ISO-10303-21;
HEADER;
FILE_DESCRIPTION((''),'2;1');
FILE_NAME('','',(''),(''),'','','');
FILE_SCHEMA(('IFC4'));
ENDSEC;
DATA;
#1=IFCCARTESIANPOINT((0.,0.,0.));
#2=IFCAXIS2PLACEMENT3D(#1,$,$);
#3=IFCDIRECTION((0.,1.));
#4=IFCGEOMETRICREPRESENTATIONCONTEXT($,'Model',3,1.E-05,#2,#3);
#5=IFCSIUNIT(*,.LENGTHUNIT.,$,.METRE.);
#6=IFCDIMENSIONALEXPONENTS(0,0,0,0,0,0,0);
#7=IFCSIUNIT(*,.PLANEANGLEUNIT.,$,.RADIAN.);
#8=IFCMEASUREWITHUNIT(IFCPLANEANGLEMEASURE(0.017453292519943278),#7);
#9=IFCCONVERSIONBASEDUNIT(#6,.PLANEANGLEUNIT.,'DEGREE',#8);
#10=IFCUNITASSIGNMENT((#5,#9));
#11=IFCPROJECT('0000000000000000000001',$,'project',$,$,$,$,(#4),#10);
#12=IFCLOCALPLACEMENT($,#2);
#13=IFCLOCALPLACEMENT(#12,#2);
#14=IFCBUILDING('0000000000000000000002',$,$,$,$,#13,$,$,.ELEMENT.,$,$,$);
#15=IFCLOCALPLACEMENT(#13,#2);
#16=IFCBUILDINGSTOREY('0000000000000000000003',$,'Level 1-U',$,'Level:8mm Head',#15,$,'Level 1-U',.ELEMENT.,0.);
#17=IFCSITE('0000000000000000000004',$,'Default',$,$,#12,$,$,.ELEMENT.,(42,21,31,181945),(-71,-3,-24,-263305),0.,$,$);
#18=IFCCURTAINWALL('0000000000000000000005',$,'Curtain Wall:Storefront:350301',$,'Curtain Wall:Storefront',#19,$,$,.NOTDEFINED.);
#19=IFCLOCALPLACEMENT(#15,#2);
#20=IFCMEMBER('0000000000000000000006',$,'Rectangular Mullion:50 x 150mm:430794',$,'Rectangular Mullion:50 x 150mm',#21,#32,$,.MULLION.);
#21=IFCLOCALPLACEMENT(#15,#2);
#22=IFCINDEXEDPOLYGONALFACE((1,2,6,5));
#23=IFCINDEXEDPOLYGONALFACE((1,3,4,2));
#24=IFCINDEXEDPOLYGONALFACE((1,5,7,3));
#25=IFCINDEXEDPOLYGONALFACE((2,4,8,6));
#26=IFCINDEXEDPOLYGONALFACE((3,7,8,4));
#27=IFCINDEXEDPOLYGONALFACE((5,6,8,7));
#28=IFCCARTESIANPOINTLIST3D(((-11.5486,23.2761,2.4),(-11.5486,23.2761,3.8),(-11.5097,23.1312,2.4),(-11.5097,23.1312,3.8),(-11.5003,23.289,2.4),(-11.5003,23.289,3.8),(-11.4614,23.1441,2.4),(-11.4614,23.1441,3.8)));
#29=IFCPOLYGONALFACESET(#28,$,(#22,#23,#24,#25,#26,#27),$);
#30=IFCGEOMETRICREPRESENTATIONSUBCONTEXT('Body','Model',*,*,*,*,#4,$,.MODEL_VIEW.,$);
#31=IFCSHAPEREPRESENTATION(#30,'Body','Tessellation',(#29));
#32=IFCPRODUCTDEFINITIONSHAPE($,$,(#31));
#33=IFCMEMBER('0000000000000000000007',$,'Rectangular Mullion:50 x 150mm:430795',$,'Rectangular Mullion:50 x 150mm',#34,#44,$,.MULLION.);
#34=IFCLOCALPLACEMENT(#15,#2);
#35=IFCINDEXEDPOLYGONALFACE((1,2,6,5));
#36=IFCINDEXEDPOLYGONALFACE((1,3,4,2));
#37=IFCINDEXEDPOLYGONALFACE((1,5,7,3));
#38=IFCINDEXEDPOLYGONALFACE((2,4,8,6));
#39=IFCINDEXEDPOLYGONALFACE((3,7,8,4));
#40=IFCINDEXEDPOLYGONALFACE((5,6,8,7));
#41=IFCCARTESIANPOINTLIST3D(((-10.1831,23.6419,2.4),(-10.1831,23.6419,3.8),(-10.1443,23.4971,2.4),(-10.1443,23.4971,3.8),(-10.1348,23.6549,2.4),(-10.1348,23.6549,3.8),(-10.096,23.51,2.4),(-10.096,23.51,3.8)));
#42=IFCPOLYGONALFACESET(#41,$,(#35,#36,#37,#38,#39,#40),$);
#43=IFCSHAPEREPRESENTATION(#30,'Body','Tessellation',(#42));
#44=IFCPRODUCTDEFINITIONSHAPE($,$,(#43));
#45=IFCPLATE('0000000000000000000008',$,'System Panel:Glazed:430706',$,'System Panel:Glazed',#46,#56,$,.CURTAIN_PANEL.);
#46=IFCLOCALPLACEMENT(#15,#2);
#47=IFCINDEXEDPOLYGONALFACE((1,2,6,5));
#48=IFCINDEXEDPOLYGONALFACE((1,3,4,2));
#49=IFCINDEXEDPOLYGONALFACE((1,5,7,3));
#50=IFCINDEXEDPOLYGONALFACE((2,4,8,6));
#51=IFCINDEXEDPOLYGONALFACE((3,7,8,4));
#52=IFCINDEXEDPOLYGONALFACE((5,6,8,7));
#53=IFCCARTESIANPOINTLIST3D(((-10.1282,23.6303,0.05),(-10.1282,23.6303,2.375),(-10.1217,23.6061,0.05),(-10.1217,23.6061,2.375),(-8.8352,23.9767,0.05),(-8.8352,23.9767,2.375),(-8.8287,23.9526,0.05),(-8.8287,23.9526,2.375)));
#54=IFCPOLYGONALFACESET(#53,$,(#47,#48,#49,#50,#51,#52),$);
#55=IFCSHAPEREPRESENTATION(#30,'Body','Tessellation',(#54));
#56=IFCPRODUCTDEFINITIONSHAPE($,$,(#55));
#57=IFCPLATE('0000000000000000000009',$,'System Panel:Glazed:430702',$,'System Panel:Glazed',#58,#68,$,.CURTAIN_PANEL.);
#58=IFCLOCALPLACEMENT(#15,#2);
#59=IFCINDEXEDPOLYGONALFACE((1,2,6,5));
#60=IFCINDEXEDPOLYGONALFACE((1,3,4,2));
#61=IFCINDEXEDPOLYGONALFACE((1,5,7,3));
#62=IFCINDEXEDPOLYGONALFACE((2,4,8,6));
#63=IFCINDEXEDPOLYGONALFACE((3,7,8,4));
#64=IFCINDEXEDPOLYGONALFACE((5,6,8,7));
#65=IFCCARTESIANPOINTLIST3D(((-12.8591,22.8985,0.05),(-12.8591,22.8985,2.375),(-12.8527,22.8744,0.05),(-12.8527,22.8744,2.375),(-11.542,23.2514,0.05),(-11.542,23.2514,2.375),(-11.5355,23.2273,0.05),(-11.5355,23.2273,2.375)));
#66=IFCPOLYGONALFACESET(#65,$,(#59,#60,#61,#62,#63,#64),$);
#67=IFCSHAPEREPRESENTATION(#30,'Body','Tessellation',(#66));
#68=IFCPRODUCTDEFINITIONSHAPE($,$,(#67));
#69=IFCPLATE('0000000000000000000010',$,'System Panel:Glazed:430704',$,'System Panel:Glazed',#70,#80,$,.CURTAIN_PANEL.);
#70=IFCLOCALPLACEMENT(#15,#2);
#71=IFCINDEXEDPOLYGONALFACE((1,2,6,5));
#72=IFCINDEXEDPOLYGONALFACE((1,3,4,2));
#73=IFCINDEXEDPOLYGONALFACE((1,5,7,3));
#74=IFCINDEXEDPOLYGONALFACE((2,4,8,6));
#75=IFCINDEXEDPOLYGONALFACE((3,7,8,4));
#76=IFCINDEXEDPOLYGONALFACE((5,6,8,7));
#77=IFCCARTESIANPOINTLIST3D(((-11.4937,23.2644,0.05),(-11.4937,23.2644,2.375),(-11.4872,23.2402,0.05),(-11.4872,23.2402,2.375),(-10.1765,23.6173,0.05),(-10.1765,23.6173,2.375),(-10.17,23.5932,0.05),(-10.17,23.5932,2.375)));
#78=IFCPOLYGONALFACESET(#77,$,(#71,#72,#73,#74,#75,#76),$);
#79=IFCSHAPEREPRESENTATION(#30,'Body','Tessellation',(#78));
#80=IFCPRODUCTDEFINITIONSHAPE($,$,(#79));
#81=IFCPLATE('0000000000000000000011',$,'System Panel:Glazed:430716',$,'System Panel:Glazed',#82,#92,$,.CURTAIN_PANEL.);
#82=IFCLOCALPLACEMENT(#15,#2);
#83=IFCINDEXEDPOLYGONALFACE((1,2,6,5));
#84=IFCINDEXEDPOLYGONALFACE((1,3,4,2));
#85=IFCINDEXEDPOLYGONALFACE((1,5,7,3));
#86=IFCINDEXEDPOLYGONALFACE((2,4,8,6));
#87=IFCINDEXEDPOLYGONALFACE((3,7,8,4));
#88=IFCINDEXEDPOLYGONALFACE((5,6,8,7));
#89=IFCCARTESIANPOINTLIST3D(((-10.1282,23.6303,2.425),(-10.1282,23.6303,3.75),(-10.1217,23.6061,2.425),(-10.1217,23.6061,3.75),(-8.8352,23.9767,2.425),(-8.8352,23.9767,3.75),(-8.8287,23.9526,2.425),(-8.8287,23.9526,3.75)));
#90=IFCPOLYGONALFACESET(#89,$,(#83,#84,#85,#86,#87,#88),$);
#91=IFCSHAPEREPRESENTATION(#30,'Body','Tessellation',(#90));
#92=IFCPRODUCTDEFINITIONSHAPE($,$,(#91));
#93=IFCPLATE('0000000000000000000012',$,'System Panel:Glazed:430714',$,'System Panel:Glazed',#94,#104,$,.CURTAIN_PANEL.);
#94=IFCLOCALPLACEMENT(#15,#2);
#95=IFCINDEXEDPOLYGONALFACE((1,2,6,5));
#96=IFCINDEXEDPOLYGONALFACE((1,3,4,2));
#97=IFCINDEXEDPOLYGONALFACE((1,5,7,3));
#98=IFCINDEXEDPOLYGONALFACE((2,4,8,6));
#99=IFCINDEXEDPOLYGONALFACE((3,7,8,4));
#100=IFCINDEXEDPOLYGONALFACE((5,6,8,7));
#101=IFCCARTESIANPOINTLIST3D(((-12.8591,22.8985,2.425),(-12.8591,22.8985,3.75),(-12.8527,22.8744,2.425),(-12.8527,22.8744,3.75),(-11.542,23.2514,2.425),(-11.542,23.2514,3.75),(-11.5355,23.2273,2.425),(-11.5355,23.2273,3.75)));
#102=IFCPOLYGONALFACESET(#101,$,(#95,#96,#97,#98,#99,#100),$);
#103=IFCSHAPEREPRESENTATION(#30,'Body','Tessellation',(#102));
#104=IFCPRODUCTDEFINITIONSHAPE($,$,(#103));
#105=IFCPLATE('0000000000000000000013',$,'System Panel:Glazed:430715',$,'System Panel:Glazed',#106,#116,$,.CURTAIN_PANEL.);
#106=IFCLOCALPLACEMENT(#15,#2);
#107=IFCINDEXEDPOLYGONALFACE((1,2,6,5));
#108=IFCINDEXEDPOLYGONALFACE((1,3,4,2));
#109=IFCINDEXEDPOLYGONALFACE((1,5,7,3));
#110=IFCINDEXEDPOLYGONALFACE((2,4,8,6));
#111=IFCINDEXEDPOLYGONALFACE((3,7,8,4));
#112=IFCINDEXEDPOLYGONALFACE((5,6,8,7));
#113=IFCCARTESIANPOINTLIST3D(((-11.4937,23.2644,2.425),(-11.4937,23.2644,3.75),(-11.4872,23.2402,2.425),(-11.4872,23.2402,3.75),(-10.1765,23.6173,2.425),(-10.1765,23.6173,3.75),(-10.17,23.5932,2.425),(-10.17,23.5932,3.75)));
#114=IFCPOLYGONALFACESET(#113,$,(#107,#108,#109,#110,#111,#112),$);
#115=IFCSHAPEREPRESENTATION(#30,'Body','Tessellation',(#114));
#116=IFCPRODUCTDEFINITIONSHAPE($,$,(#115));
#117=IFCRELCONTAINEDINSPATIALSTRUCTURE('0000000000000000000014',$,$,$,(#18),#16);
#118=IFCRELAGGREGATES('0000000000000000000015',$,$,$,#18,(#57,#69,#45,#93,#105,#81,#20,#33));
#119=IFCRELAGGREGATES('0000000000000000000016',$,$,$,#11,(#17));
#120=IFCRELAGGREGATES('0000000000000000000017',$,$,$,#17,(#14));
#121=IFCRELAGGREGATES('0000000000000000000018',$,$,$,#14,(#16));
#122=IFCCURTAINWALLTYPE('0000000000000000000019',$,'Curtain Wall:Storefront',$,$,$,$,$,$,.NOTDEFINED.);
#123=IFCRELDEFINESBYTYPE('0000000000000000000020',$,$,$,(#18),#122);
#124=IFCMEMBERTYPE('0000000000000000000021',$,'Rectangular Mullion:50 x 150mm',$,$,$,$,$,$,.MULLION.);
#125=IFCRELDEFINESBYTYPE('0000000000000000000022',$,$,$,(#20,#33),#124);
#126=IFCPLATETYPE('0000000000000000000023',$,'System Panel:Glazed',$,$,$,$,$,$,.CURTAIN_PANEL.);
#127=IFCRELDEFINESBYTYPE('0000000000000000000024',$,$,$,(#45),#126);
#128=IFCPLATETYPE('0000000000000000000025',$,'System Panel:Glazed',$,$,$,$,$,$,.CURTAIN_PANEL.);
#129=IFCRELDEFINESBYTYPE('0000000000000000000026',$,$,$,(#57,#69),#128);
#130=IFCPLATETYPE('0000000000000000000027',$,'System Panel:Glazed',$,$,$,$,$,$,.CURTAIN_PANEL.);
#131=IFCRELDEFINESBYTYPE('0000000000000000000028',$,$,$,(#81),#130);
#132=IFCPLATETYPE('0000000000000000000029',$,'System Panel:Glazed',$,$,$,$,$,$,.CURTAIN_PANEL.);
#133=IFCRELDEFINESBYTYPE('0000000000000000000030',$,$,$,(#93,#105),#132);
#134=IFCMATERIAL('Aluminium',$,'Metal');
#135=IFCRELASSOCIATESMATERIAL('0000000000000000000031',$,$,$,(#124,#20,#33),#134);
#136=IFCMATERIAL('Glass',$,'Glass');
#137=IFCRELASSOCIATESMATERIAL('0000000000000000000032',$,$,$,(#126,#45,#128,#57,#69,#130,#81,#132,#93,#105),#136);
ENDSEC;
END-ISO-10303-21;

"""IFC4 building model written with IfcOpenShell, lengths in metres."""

from ifc_helpers import new_model, entity, si_unit, converted_unit, direction, frame, origin, place, context, subcontext, project, spatial, indexed_curve, outline, extrude, source, transform, mapped, material, type_object, type_shapes, element, aggregate, save


model = new_model("IFC4")

# Units and contexts
model_context = context("Model", 3, precision=1e-05, world=origin(), true_north=direction((0.0, 1.0)))
body_context = subcontext(model_context, "Body", "Model", "MODEL_VIEW")
ifc_project = project(units=[si_unit("LENGTHUNIT", "METRE"), converted_unit("PLANEANGLEUNIT", "DEGREE", entity("IfcPlaneAngleMeasure", 0.017453292519943278), si_unit("PLANEANGLEUNIT", "RADIAN"), dimensions=[0, 0, 0, 0, 0, 0, 0])], contexts=[model_context])

# Site, building, storey
site_placement = place(None, origin())
site = spatial("IfcSite", under=ifc_project, at=site_placement, Name="Default", CompositionType="ELEMENT", RefLatitude=(42, 21, 31, 181945), RefLongitude=(-71, -3, -24, -263305), RefElevation=0.0)
building_placement = place(site_placement, origin())
building = spatial("IfcBuilding", under=site, at=building_placement, CompositionType="ELEMENT")
storey_placement = place(building_placement, origin())
storey = spatial("IfcBuildingStorey", under=building, at=storey_placement, Name="Level 1-U", ObjectType="Level:8mm Head", LongName="Level 1-U", CompositionType="ELEMENT", Elevation=0.0)

# Curtain wall, members, plates
curtain_wall_type = type_object("IfcCurtainWallType", Name="Curtain Wall:Storefront", PredefinedType="NOTDEFINED")
curtain_wall_placement = place(storey_placement, origin())
curtain_wall = element("IfcCurtainWall", 1, at=curtain_wall_placement, inside=storey, type_object=curtain_wall_type, Name="Curtain Wall:Storefront:350301", ObjectType="Curtain Wall:Storefront", PredefinedType="NOTDEFINED")
ifc_material_1 = material(Name="Aluminium", Category="Metal")
member_type_1 = type_object("IfcMemberType", Name="Rectangular Mullion:50 x 150mm", PredefinedType="MULLION", material=ifc_material_1)
shared_shape_1 = source(origin(), body_context, "Body", "SweptSolid", [
    extrude(outline(indexed_curve([(-0.025, -0.075), (0.025, -0.075), (0.025, 0.075), (-0.025, 0.075), (-0.025, -0.075)], self_intersect=False)), frame((0.0, 0.0, -1.4), z_axis=(0.0, 0.0, 1.0), x_axis=(-1.0, 0.0, 0.0)), (0.0, 0.0, 1.0), 1.4),
])
type_shapes(member_type_1, [shared_shape_1])
member_1_placement = place(curtain_wall_placement, frame((-11.505, 23.2101, 2.4), z_axis=(0.0, 0.0, -1.0), x_axis=(0.965926, 0.258819, 0.0)))
member_1 = element("IfcMember", 2, at=member_1_placement, type_object=member_type_1, material=ifc_material_1, Name="Rectangular Mullion:50 x 150mm:430794", ObjectType="Rectangular Mullion:50 x 150mm", PredefinedType="MULLION", context=body_context, shape_type="MappedRepresentation", body=[
    mapped(shared_shape_1, transform((0.0, 0.0, 0.0), scale=1.0)),
])
member_2_placement = place(curtain_wall_placement, frame((-10.1395, 23.576, 2.4), z_axis=(0.0, 0.0, -1.0), x_axis=(0.965926, 0.258819, 0.0)))
member_2 = element("IfcMember", 3, at=member_2_placement, type_object=member_type_1, material=ifc_material_1, Name="Rectangular Mullion:50 x 150mm:430795", ObjectType="Rectangular Mullion:50 x 150mm", PredefinedType="MULLION", context=body_context, shape_type="MappedRepresentation", body=[
    mapped(shared_shape_1, transform((0.0, 0.0, 0.0), scale=1.0)),
])
ifc_material_2 = material(Name="Glass", Category="Glass")
plate_type_1 = type_object("IfcPlateType", Name="System Panel:Glazed", PredefinedType="CURTAIN_PANEL", material=ifc_material_2)
shared_shape_2 = source(origin(), body_context, "Body", "SweptSolid", [
    extrude(outline(indexed_curve([(-0.0125, -0.6693), (0.0125, -0.6693), (0.0125, 0.6693), (-0.0125, 0.6693), (-0.0125, -0.6693)], self_intersect=False)), frame((0.0, 0.037, 0.0), z_axis=(0.0, 0.0, 1.0), x_axis=(0.0, 1.0, 0.0)), (0.0, 0.0, 1.0), 2.325),
])
type_shapes(plate_type_1, [shared_shape_2])
plate_1_placement = place(curtain_wall_placement, frame((-9.4689, 23.7557, 0.05), z_axis=(0.0, 0.0, 1.0), x_axis=(0.965926, 0.258819, 0.0)))
plate_1 = element("IfcPlate", 4, at=plate_1_placement, type_object=plate_type_1, material=ifc_material_2, Name="System Panel:Glazed:430706", ObjectType="System Panel:Glazed", PredefinedType="CURTAIN_PANEL", context=body_context, shape_type="MappedRepresentation", body=[
    mapped(shared_shape_2, transform((0.0, 0.0, 0.0), scale=1.0)),
])
plate_type_2 = type_object("IfcPlateType", Name="System Panel:Glazed", PredefinedType="CURTAIN_PANEL", material=ifc_material_2)
shared_shape_3 = source(origin(), body_context, "Body", "SweptSolid", [
    extrude(outline(indexed_curve([(-0.0125, -0.6818), (0.0125, -0.6818), (0.0125, 0.6818), (-0.0125, 0.6818), (-0.0125, -0.6818)], self_intersect=False)), frame((0.0, 0.037, 0.0), z_axis=(0.0, 0.0, 1.0), x_axis=(0.0, 1.0, 0.0)), (0.0, 0.0, 1.0), 2.325),
])
type_shapes(plate_type_2, [shared_shape_3])
plate_2_placement = place(curtain_wall_placement, frame((-12.1877, 23.0272, 0.05), z_axis=(0.0, 0.0, 1.0), x_axis=(0.965926, 0.258819, 0.0)))
plate_2 = element("IfcPlate", 5, at=plate_2_placement, type_object=plate_type_2, material=ifc_material_2, Name="System Panel:Glazed:430702", ObjectType="System Panel:Glazed", PredefinedType="CURTAIN_PANEL", context=body_context, shape_type="MappedRepresentation", body=[
    mapped(shared_shape_3, transform((0.0, 0.0, 0.0), scale=1.0)),
])
plate_3_placement = place(curtain_wall_placement, frame((-10.8223, 23.393, 0.05), z_axis=(0.0, 0.0, 1.0), x_axis=(0.965926, 0.258819, 0.0)))
plate_3 = element("IfcPlate", 6, at=plate_3_placement, type_object=plate_type_2, material=ifc_material_2, Name="System Panel:Glazed:430704", ObjectType="System Panel:Glazed", PredefinedType="CURTAIN_PANEL", context=body_context, shape_type="MappedRepresentation", body=[
    mapped(shared_shape_3, transform((0.0, 0.0, 0.0), scale=1.0)),
])
plate_type_3 = type_object("IfcPlateType", Name="System Panel:Glazed", PredefinedType="CURTAIN_PANEL", material=ifc_material_2)
shared_shape_4 = source(origin(), body_context, "Body", "SweptSolid", [
    extrude(outline(indexed_curve([(-0.0125, -0.6693), (0.0125, -0.6693), (0.0125, 0.6693), (-0.0125, 0.6693), (-0.0125, -0.6693)], self_intersect=False)), frame((0.0, 0.037, 0.0), z_axis=(0.0, 0.0, 1.0), x_axis=(0.0, 1.0, 0.0)), (0.0, 0.0, 1.0), 1.325),
])
type_shapes(plate_type_3, [shared_shape_4])
plate_4_placement = place(curtain_wall_placement, frame((-9.4689, 23.7557, 2.425), z_axis=(0.0, 0.0, 1.0), x_axis=(0.965926, 0.258819, 0.0)))
plate_4 = element("IfcPlate", 7, at=plate_4_placement, type_object=plate_type_3, material=ifc_material_2, Name="System Panel:Glazed:430716", ObjectType="System Panel:Glazed", PredefinedType="CURTAIN_PANEL", context=body_context, shape_type="MappedRepresentation", body=[
    mapped(shared_shape_4, transform((0.0, 0.0, 0.0), scale=1.0)),
])
plate_type_4 = type_object("IfcPlateType", Name="System Panel:Glazed", PredefinedType="CURTAIN_PANEL", material=ifc_material_2)
shared_shape_5 = source(origin(), body_context, "Body", "SweptSolid", [
    extrude(outline(indexed_curve([(-0.0125, -0.6818), (0.0125, -0.6818), (0.0125, 0.6818), (-0.0125, 0.6818), (-0.0125, -0.6818)], self_intersect=False)), frame((0.0, 0.037, 0.0), z_axis=(0.0, 0.0, 1.0), x_axis=(0.0, 1.0, 0.0)), (0.0, 0.0, 1.0), 1.325),
])
type_shapes(plate_type_4, [shared_shape_5])
plate_5_placement = place(curtain_wall_placement, frame((-12.1877, 23.0272, 2.425), z_axis=(0.0, 0.0, 1.0), x_axis=(0.965926, 0.258819, 0.0)))
plate_5 = element("IfcPlate", 8, at=plate_5_placement, type_object=plate_type_4, material=ifc_material_2, Name="System Panel:Glazed:430714", ObjectType="System Panel:Glazed", PredefinedType="CURTAIN_PANEL", context=body_context, shape_type="MappedRepresentation", body=[
    mapped(shared_shape_5, transform((0.0, 0.0, 0.0), scale=1.0)),
])
plate_6_placement = place(curtain_wall_placement, frame((-10.8223, 23.393, 2.425), z_axis=(0.0, 0.0, 1.0), x_axis=(0.965926, 0.258819, 0.0)))
plate_6 = element("IfcPlate", 9, at=plate_6_placement, type_object=plate_type_4, material=ifc_material_2, Name="System Panel:Glazed:430715", ObjectType="System Panel:Glazed", PredefinedType="CURTAIN_PANEL", context=body_context, shape_type="MappedRepresentation", body=[
    mapped(shared_shape_5, transform((0.0, 0.0, 0.0), scale=1.0)),
])
aggregate(curtain_wall, [plate_2, plate_3, plate_1, plate_5, plate_6, plate_4, member_1, member_2])

save(model, "model.ifc")
